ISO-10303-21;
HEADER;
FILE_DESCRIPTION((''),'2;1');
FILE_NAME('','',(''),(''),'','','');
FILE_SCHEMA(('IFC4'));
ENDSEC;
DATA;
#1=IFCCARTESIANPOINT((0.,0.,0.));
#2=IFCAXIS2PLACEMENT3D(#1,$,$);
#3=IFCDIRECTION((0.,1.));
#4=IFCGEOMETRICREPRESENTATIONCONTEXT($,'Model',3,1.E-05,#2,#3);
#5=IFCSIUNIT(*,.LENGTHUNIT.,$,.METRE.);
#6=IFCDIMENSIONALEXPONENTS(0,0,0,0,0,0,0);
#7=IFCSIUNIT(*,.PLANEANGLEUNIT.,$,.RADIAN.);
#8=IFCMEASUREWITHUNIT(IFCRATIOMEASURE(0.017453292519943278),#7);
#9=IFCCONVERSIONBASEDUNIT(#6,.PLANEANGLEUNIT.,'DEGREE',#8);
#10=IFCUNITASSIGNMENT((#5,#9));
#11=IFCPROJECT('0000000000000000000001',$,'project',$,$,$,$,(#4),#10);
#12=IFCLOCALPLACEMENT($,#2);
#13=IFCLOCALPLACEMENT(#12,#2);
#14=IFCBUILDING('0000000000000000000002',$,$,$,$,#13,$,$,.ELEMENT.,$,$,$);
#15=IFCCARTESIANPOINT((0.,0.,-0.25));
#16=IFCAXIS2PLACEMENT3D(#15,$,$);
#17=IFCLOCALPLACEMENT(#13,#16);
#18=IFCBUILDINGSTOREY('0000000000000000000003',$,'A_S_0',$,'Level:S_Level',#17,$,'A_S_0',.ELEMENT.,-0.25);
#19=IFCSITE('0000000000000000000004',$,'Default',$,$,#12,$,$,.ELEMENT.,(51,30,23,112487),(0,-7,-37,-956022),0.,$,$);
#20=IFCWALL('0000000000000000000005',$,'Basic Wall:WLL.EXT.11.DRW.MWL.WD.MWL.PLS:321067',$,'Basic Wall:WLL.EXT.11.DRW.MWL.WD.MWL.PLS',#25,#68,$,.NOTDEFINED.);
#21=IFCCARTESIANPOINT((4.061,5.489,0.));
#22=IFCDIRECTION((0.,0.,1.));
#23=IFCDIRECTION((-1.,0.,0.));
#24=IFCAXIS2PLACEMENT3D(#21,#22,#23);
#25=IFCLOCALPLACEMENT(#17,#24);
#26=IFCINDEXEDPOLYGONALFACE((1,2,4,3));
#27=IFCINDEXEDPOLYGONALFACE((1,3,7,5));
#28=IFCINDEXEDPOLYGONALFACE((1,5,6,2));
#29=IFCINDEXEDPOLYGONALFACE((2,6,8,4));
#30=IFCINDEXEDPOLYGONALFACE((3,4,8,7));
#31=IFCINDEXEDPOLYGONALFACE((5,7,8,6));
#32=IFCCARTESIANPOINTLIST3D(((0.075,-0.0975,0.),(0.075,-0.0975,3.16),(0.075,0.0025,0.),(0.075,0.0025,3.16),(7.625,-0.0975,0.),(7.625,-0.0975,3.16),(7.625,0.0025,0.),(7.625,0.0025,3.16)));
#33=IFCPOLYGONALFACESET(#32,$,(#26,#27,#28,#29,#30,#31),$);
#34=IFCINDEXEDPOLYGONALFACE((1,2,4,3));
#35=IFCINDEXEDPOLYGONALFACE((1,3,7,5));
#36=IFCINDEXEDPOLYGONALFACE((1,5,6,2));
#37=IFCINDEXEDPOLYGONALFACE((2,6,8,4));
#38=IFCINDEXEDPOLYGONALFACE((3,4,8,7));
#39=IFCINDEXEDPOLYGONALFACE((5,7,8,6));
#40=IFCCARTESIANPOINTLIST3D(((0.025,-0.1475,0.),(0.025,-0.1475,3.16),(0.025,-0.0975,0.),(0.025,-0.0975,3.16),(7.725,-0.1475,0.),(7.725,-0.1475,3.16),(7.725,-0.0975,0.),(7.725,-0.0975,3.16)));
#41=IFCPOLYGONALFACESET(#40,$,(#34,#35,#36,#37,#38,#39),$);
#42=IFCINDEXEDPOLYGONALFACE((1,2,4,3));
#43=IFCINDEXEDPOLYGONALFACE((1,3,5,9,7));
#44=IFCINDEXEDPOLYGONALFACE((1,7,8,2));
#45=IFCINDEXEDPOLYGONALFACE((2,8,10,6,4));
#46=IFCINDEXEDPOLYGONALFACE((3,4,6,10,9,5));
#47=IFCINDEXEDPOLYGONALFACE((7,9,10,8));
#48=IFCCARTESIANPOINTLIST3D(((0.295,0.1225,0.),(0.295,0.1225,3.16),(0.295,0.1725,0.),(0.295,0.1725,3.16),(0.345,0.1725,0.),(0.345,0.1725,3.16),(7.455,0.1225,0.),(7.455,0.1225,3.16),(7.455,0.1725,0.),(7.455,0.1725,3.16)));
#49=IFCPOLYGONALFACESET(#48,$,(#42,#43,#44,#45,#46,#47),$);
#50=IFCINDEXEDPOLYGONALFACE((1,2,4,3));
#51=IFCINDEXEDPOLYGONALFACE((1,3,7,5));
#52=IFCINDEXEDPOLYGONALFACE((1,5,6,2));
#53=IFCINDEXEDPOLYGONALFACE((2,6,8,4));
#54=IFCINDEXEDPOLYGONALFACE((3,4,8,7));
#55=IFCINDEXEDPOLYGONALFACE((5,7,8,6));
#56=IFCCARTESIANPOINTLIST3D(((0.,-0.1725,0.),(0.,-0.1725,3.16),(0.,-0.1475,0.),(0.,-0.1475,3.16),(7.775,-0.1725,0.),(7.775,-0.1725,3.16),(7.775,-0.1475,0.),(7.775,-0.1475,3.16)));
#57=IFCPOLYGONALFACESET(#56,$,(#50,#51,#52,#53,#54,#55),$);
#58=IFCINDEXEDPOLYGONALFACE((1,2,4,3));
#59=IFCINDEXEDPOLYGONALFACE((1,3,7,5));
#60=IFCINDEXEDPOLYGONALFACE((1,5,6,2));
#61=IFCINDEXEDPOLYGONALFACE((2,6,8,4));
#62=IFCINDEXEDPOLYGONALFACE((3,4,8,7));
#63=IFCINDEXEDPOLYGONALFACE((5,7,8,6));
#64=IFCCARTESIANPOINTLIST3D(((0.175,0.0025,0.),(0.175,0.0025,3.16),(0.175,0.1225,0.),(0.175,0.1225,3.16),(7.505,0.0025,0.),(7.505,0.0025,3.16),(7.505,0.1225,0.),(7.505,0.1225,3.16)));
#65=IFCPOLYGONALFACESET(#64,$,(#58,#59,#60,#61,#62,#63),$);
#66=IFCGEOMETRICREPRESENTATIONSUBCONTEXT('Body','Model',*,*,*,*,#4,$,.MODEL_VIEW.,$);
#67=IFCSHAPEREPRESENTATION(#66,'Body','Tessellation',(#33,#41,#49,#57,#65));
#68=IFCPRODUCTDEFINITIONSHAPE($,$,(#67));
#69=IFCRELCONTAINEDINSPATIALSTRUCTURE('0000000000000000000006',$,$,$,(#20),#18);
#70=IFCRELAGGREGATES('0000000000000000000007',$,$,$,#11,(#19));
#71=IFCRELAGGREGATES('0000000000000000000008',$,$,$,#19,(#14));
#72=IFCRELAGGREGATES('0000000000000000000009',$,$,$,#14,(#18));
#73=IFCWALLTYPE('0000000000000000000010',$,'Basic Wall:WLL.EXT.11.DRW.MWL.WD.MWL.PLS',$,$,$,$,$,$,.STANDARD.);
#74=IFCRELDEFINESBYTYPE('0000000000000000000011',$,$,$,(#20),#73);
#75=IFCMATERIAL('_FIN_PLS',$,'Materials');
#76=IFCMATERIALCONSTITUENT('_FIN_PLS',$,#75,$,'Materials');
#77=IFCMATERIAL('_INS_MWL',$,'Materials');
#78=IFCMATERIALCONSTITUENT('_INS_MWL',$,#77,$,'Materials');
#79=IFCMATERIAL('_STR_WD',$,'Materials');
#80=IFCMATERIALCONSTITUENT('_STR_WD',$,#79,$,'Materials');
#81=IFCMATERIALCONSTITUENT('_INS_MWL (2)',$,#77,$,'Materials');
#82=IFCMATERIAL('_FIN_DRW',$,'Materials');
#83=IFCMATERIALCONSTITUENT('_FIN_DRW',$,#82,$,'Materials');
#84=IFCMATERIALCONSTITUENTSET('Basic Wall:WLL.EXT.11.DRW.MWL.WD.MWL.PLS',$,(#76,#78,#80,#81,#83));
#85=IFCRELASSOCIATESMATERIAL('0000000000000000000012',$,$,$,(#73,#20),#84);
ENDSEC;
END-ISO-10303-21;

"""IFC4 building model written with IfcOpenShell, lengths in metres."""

from ifc_helpers import new_model, entity, si_unit, converted_unit, direction, frame, origin, place, context, subcontext, project, spatial, indexed_curve, outline, extrude, material, constituent, constituent_set, type_object, element, save


model = new_model("IFC4")

# Units and contexts
model_context = context("Model", 3, precision=1e-05, world=origin(), true_north=direction((0.0, 1.0)))
body_context = subcontext(model_context, "Body", "Model", "MODEL_VIEW")
ifc_project = project(units=[si_unit("LENGTHUNIT", "METRE"), converted_unit("PLANEANGLEUNIT", "DEGREE", entity("IfcRatioMeasure", 0.017453292519943278), si_unit("PLANEANGLEUNIT", "RADIAN"), dimensions=[0, 0, 0, 0, 0, 0, 0])], contexts=[model_context])

# Site, building, storey
site_placement = place(None, origin())
site = spatial("IfcSite", under=ifc_project, at=site_placement, Name="Default", CompositionType="ELEMENT", RefLatitude=(51, 30, 23, 112487), RefLongitude=(0, -7, -37, -956022), RefElevation=0.0)
building_placement = place(site_placement, origin())
building = spatial("IfcBuilding", under=site, at=building_placement, CompositionType="ELEMENT")
storey_placement = place(building_placement, frame((0.0, 0.0, -0.25)))
storey = spatial("IfcBuildingStorey", under=building, at=storey_placement, Name="A_S_0", ObjectType="Level:S_Level", LongName="A_S_0", CompositionType="ELEMENT", Elevation=-0.25)

# Shared definitions
ifc_material_1 = material(Name="_FIN_PLS", Category="Materials")

# Wall
ifc_constituent_1 = constituent(ifc_material_1, Name="_FIN_PLS", Category="Materials")
ifc_material_2 = material(Name="_INS_MWL", Category="Materials")
ifc_constituent_2 = constituent(ifc_material_2, Name="_INS_MWL", Category="Materials")
ifc_material_3 = material(Name="_STR_WD", Category="Materials")
ifc_constituent_3 = constituent(ifc_material_3, Name="_STR_WD", Category="Materials")
ifc_constituent_4 = constituent(ifc_material_2, Name="_INS_MWL (2)", Category="Materials")
ifc_material_4 = material(Name="_FIN_DRW", Category="Materials")
ifc_constituent_5 = constituent(ifc_material_4, Name="_FIN_DRW", Category="Materials")
ifc_constituent_set_1 = constituent_set(constituents=[ifc_constituent_1, ifc_constituent_2, ifc_constituent_3, ifc_constituent_4, ifc_constituent_5], Name="Basic Wall:WLL.EXT.11.DRW.MWL.WD.MWL.PLS")
wall_type_1 = type_object("IfcWallType", Name="Basic Wall:WLL.EXT.11.DRW.MWL.WD.MWL.PLS", PredefinedType="STANDARD", material=ifc_constituent_set_1)
wall_1_placement = place(storey_placement, frame((4.061, 5.489, 0.0), z_axis=(0.0, 0.0, 1.0), x_axis=(-1.0, 0.0, 0.0)))
element("IfcWall", 1, at=wall_1_placement, inside=storey, type_object=wall_type_1, material=ifc_constituent_set_1, Name="Basic Wall:WLL.EXT.11.DRW.MWL.WD.MWL.PLS:321067", ObjectType="Basic Wall:WLL.EXT.11.DRW.MWL.WD.MWL.PLS", PredefinedType="NOTDEFINED", context=body_context, shape_type="SweptSolid", body=[
    extrude(outline(indexed_curve([(-3.775, -0.05), (3.775, -0.05), (3.775, 0.05), (-3.775, 0.05), (-3.775, -0.05)], self_intersect=False)), frame((3.85, -0.0475, 0.0)), (0.0, 0.0, 1.0), 3.16),
    extrude(outline(indexed_curve([(-3.85, -0.025), (3.85, -0.025), (3.85, 0.025), (-3.85, 0.025), (-3.85, -0.025)], self_intersect=False)), frame((3.875, -0.1225, 0.0)), (0.0, 0.0, 1.0), 3.16),
    extrude(outline(indexed_curve([(2.824, -0.02), (2.874, -0.02), (2.874, 0.03), (-4.286, 0.03), (-4.286, -0.02), (2.824, -0.02)], self_intersect=False)), frame((3.169, 0.1525, 0.0), z_axis=(0.0, 0.0, 1.0), x_axis=(-1.0, 0.0, 0.0)), (0.0, 0.0, 1.0), 3.16),
    extrude(outline(indexed_curve([(-0.0125, -3.8875), (0.0125, -3.8875), (0.0125, 3.8875), (-0.0125, 3.8875), (-0.0125, -3.8875)], self_intersect=False)), frame((3.8875, -0.16, 0.0), z_axis=(0.0, 0.0, 1.0), x_axis=(0.0, 1.0, 0.0)), (0.0, 0.0, 1.0), 3.16),
    extrude(outline(indexed_curve([(-3.665, -0.06), (3.665, -0.06), (3.665, 0.06), (-3.665, 0.06), (-3.665, -0.06)], self_intersect=False)), frame((3.84, 0.0625, 0.0)), (0.0, 0.0, 1.0), 3.16),
])

save(model, "model.ifc")
